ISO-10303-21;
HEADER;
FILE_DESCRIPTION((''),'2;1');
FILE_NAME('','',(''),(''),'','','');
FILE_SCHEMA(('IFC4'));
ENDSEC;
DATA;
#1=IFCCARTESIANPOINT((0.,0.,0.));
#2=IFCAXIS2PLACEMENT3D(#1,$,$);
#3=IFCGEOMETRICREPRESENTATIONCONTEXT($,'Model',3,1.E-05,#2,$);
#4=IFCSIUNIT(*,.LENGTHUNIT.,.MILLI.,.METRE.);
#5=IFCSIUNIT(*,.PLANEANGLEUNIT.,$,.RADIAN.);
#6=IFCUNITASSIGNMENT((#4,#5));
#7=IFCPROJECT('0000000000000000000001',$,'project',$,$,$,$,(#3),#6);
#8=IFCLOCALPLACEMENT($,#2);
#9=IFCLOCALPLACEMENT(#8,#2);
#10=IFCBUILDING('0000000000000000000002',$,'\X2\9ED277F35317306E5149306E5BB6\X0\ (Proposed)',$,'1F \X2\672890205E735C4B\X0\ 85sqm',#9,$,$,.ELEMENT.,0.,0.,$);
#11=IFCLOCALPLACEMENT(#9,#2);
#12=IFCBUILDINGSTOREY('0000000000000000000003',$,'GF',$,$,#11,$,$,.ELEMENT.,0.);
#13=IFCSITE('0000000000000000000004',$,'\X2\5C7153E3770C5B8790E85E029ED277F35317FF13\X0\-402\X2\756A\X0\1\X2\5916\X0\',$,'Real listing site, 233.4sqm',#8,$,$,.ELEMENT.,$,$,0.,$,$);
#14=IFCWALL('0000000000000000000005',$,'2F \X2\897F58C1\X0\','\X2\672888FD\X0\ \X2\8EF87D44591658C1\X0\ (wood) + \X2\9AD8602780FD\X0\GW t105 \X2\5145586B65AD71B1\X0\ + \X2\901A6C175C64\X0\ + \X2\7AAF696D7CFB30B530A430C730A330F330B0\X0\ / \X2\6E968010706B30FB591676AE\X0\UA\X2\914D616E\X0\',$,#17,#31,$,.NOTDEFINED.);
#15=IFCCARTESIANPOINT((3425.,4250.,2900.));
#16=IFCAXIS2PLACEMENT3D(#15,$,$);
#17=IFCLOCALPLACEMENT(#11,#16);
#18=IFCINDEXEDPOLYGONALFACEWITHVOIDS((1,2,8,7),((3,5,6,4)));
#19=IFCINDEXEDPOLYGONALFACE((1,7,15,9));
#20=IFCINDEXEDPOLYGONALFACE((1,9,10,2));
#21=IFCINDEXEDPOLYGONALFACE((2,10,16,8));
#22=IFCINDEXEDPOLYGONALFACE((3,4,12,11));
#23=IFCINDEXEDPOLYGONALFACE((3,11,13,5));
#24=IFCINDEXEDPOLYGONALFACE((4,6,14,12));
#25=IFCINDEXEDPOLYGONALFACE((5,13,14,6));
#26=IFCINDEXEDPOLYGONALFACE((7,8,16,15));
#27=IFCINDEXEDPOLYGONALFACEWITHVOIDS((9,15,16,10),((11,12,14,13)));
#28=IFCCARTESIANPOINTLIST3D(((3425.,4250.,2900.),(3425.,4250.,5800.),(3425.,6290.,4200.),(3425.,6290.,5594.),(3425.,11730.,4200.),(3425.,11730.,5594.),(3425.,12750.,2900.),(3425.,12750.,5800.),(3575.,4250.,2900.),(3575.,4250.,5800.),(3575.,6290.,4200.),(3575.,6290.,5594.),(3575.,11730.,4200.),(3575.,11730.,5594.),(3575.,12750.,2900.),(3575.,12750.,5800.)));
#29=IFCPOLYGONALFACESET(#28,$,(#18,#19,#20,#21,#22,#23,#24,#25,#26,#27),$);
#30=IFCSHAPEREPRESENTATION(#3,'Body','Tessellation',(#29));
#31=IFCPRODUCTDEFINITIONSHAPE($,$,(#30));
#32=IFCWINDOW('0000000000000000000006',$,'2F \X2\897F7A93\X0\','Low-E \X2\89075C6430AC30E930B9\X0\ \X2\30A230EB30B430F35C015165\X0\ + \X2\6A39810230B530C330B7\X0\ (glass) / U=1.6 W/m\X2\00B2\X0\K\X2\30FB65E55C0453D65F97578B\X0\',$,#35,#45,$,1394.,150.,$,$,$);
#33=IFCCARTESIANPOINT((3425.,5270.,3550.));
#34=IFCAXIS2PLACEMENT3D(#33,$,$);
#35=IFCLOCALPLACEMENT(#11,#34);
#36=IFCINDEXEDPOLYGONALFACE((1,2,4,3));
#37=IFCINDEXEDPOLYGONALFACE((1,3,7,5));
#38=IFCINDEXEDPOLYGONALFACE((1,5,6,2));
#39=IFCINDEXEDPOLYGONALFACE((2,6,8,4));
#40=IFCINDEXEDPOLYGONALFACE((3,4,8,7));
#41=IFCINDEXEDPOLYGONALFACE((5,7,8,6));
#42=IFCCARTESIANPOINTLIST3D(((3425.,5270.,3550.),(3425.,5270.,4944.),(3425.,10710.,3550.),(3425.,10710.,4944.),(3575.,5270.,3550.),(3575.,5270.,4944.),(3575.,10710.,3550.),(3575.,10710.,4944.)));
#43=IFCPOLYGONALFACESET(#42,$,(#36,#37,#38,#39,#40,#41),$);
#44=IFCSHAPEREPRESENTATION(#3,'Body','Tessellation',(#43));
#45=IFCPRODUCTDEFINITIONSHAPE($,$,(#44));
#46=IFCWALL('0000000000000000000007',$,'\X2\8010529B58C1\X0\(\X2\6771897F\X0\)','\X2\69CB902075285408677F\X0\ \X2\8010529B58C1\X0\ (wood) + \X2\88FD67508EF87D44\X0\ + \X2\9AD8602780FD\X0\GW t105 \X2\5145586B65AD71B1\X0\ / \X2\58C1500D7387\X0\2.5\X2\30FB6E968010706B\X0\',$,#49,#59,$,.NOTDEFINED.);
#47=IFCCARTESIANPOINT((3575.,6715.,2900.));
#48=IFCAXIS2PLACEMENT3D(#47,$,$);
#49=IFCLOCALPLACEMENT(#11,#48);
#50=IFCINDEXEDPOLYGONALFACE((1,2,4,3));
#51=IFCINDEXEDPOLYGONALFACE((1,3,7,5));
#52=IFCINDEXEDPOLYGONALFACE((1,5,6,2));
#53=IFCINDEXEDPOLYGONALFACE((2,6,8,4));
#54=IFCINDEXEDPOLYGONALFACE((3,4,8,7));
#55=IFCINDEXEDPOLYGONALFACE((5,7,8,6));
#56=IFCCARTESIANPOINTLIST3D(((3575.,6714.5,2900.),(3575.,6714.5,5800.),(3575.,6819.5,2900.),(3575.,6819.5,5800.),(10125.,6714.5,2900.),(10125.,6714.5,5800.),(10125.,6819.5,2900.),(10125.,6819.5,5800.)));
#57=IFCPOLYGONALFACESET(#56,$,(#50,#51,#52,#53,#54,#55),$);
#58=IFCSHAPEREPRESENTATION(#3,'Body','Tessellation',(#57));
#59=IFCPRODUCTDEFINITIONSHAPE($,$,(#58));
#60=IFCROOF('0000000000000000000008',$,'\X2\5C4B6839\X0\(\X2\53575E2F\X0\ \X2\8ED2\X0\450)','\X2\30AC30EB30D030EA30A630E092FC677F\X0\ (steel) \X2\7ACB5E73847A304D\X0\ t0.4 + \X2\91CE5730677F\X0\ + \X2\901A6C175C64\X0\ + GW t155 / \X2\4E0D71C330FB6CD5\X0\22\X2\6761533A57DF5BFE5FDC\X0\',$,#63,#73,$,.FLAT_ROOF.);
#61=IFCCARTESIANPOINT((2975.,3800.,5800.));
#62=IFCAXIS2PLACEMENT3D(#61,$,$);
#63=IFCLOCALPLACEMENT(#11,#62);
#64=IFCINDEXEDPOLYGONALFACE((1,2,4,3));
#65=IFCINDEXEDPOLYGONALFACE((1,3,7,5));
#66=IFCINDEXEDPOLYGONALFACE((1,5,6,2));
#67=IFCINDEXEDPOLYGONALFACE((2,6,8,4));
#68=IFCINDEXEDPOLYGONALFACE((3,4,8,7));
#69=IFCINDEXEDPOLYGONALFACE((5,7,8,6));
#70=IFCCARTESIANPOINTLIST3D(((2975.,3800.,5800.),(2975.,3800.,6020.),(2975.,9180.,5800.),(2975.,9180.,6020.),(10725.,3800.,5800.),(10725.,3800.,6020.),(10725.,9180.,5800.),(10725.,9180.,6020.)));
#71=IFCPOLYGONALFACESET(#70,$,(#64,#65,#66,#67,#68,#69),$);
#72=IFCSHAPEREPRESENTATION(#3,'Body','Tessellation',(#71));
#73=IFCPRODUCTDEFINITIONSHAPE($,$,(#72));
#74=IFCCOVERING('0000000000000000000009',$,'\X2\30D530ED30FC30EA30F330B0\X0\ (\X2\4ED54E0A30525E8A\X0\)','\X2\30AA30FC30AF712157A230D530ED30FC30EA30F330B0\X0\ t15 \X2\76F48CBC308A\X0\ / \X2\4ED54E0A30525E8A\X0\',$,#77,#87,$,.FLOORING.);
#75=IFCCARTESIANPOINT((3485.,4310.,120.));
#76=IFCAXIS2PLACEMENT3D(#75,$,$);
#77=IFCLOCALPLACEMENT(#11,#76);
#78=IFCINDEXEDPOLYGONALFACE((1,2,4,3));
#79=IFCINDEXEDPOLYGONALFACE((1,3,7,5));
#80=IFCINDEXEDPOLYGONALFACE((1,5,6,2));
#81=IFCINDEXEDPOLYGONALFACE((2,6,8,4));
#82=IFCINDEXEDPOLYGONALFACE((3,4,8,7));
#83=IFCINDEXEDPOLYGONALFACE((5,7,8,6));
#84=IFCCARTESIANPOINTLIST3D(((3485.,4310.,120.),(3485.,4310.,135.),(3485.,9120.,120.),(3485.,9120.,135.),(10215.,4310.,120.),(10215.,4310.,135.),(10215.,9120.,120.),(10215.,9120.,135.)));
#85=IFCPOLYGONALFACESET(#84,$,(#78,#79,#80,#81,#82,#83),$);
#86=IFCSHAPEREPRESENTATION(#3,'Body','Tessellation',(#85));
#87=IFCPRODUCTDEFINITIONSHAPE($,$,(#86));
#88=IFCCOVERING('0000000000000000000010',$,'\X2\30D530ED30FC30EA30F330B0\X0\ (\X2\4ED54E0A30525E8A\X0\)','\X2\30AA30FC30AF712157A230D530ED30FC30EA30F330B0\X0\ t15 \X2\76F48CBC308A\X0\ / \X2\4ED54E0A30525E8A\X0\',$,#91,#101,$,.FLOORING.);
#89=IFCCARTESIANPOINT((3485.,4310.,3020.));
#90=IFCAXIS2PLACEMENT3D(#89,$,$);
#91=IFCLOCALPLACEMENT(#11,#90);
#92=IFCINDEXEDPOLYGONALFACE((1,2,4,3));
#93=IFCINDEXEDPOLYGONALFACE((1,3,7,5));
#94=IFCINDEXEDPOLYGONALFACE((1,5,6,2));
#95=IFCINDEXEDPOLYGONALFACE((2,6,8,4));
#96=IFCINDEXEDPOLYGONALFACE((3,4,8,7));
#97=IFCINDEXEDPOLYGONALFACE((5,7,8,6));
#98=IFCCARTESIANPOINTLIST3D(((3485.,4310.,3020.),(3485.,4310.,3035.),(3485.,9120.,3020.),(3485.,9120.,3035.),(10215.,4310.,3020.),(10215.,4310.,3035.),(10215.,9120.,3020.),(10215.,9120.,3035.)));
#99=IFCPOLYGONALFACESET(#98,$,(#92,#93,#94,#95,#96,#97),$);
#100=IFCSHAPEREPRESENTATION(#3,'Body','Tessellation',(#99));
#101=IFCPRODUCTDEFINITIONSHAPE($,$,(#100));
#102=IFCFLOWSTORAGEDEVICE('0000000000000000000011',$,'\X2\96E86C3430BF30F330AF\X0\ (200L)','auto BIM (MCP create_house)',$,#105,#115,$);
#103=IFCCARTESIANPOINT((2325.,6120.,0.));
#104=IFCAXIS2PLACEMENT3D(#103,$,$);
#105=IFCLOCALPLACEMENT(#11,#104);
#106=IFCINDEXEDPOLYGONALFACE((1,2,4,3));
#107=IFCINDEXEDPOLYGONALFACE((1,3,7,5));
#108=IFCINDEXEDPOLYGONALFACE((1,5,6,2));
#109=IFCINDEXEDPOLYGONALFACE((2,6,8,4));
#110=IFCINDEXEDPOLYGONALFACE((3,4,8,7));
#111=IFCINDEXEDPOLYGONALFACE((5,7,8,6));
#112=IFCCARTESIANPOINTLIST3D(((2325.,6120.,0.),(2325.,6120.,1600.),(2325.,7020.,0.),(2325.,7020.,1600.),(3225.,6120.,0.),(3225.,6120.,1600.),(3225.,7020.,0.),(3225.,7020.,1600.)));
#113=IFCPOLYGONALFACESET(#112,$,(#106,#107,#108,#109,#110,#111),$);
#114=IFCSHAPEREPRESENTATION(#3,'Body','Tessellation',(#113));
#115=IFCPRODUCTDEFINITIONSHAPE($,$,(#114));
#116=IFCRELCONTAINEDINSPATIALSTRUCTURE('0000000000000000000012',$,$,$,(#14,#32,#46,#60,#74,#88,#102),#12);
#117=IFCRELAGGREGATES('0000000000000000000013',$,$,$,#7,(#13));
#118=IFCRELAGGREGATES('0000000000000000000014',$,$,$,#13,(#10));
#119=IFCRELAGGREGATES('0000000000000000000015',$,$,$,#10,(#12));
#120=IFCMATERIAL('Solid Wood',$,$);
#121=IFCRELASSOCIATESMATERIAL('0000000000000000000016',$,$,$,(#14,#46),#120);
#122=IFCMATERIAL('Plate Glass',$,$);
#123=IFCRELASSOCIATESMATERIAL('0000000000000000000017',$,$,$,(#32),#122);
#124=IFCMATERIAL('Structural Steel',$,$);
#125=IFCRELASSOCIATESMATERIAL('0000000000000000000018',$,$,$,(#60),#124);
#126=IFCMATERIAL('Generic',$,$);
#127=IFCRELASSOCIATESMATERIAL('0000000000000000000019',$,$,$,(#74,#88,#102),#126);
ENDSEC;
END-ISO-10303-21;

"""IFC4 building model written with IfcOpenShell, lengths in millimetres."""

from ifc_helpers import new_model, si_unit, frame, frame_2d, origin, place, context, project, spatial, rectangle, extrude, material, element, fill, save


model = new_model("IFC4")

# Units and contexts
model_context = context("Model", 3, precision=1e-05, world=origin())
ifc_project = project(units=[si_unit("LENGTHUNIT", "METRE", prefix="MILLI"), si_unit("PLANEANGLEUNIT", "RADIAN")], contexts=[model_context])

# Site, building, storey
site_placement = place(None, origin())
site = spatial("IfcSite", under=ifc_project, at=site_placement, Name="山口県宇部市黒石北３-402番1外", ObjectType="Real listing site, 233.4sqm", CompositionType="ELEMENT", RefElevation=0.0)
building_placement = place(site_placement, origin())
building = spatial("IfcBuilding", under=site, at=building_placement, Name="黒石北の光の家 (Proposed)", ObjectType="1F 木造平屋 85sqm", CompositionType="ELEMENT", ElevationOfRefHeight=0.0, ElevationOfTerrain=0.0)
storey_placement = place(building_placement, origin())
storey = spatial("IfcBuildingStorey", under=building, at=storey_placement, Name="GF", CompositionType="ELEMENT", Elevation=0.0)

# Shared definitions
ifc_material_1 = material(Name="Solid Wood")
ifc_material_2 = material(Name="Generic")

# Shared definitions
ifc_material_3 = material(Name="Plate Glass")

# Wall, opening, window
wall_1_placement = place(storey_placement, frame((3425.0, 4250.0, 2900.0)))
wall_1 = element("IfcWall", 1, at=wall_1_placement, inside=storey, material=ifc_material_1, Name="2F 西壁", Description="木製 軸組外壁 (wood) + 高性能GW t105 充填断熱 + 通気層 + 窯業系サイディング / 準耐火・外皮UA配慮", PredefinedType="NOTDEFINED", context=model_context, shape_type="SweptSolid", body=[
    extrude(rectangle(XDim=150.0, YDim=8500.0, at=frame_2d((75.0, 4250.0))), frame((3425.0, 4250.0, 2900.0)), (0.0, 0.0, 1.0), 2900.0),
])
opening_1_placement = place(storey_placement, frame((3425.0, 5270.0, 3550.0)))
opening_1 = element("IfcOpeningElement", 2, at=opening_1_placement, cuts=wall_1, PredefinedType="NOTDEFINED", context=model_context, shape_type="SweptSolid", body=[
    extrude(rectangle(XDim=150.0, YDim=5440.0, at=frame_2d((75.0, 2720.0))), frame((3425.0, 5270.0, 3550.0)), (0.0, 0.0, 1.0), 1394.0),
])
window_1_placement = place(storey_placement, frame((3425.0, 5270.0, 3550.0)))
window_1 = element("IfcWindow", 3, at=window_1_placement, inside=storey, material=ifc_material_3, Name="2F 西窓", Description="Low-E 複層ガラス アルゴン封入 + 樹脂サッシ (glass) / U=1.6 W/m²K・日射取得型", OverallHeight=1394.0, OverallWidth=150.0, context=model_context, shape_type="SweptSolid", body=[
    extrude(rectangle(XDim=150.0, YDim=5440.0, at=frame_2d((75.0, 2720.0))), frame((3425.0, 5270.0, 3550.0)), (0.0, 0.0, 1.0), 1394.0),
])
fill(opening_1, window_1)

# Wall
wall_2_placement = place(storey_placement, frame((3575.0, 6715.0, 2900.0)))
element("IfcWall", 4, at=wall_2_placement, inside=storey, material=ifc_material_1, Name="耐力壁(東西)", Description="構造用合板 耐力壁 (wood) + 製材軸組 + 高性能GW t105 充填断熱 / 壁倍率2.5・準耐火", PredefinedType="NOTDEFINED", context=model_context, shape_type="SweptSolid", body=[
    extrude(rectangle(XDim=6550.0, YDim=105.0, at=frame_2d((3275.0, 52.0))), frame((3575.0, 6715.0, 2900.0)), (0.0, 0.0, 1.0), 2900.0),
])

# Roof
ifc_material_4 = material(Name="Structural Steel")
for number, where, name in (
    (5, (2975.0, 3800.0, 5800.0), "屋根(南帯 軒450)"),
):
    element("IfcRoof", number, at=place(storey_placement, frame(where)), inside=storey, material=ifc_material_4, Name=name, Description="ガルバリウム鋼板 (steel) 立平葺き t0.4 + 野地板 + 通気層 + GW t155 / 不燃・法22条区域対応", PredefinedType="FLAT_ROOF", context=model_context, shape_type="SweptSolid", body=[
        extrude(rectangle(XDim=7750.0, YDim=5380.0, at=frame_2d((3875.0, 2690.0))), frame((2975.0, 3800.0, 5800.0)), (0.0, 0.0, 1.0), 220.0),
    ])

# Coverings
covering_1_placement = place(storey_placement, frame((3485.0, 4310.0, 120.0)))
element("IfcCovering", 6, at=covering_1_placement, inside=storey, material=ifc_material_2, Name="フローリング (仕上げ床)", Description="オーク無垢フローリング t15 直貼り / 仕上げ床", PredefinedType="FLOORING", context=model_context, shape_type="SweptSolid", body=[
    extrude(rectangle(XDim=6730.0, YDim=4810.0, at=frame_2d((3365.0, 2405.0))), frame((3485.0, 4310.0, 120.0)), (0.0, 0.0, 1.0), 15.0),
])
covering_2_placement = place(storey_placement, frame((3485.0, 4310.0, 3020.0)))
element("IfcCovering", 7, at=covering_2_placement, inside=storey, material=ifc_material_2, Name="フローリング (仕上げ床)", Description="オーク無垢フローリング t15 直貼り / 仕上げ床", PredefinedType="FLOORING", context=model_context, shape_type="SweptSolid", body=[
    extrude(rectangle(XDim=6730.0, YDim=4810.0, at=frame_2d((3365.0, 2405.0))), frame((3485.0, 4310.0, 3020.0)), (0.0, 0.0, 1.0), 15.0),
])

# Flow storage device
flow_storage_device_placement = place(storey_placement, frame((2325.0, 6120.0, 0.0)))
element("IfcFlowStorageDevice", 8, at=flow_storage_device_placement, inside=storey, material=ifc_material_2, Name="雨水タンク (200L)", Description="auto BIM (MCP create_house)", context=model_context, shape_type="SweptSolid", body=[
    extrude(rectangle(XDim=900.0, YDim=900.0, at=frame_2d((450.0, 450.0))), frame((2325.0, 6120.0, 0.0)), (0.0, 0.0, 1.0), 1600.0),
])

save(model, "model.ifc")
